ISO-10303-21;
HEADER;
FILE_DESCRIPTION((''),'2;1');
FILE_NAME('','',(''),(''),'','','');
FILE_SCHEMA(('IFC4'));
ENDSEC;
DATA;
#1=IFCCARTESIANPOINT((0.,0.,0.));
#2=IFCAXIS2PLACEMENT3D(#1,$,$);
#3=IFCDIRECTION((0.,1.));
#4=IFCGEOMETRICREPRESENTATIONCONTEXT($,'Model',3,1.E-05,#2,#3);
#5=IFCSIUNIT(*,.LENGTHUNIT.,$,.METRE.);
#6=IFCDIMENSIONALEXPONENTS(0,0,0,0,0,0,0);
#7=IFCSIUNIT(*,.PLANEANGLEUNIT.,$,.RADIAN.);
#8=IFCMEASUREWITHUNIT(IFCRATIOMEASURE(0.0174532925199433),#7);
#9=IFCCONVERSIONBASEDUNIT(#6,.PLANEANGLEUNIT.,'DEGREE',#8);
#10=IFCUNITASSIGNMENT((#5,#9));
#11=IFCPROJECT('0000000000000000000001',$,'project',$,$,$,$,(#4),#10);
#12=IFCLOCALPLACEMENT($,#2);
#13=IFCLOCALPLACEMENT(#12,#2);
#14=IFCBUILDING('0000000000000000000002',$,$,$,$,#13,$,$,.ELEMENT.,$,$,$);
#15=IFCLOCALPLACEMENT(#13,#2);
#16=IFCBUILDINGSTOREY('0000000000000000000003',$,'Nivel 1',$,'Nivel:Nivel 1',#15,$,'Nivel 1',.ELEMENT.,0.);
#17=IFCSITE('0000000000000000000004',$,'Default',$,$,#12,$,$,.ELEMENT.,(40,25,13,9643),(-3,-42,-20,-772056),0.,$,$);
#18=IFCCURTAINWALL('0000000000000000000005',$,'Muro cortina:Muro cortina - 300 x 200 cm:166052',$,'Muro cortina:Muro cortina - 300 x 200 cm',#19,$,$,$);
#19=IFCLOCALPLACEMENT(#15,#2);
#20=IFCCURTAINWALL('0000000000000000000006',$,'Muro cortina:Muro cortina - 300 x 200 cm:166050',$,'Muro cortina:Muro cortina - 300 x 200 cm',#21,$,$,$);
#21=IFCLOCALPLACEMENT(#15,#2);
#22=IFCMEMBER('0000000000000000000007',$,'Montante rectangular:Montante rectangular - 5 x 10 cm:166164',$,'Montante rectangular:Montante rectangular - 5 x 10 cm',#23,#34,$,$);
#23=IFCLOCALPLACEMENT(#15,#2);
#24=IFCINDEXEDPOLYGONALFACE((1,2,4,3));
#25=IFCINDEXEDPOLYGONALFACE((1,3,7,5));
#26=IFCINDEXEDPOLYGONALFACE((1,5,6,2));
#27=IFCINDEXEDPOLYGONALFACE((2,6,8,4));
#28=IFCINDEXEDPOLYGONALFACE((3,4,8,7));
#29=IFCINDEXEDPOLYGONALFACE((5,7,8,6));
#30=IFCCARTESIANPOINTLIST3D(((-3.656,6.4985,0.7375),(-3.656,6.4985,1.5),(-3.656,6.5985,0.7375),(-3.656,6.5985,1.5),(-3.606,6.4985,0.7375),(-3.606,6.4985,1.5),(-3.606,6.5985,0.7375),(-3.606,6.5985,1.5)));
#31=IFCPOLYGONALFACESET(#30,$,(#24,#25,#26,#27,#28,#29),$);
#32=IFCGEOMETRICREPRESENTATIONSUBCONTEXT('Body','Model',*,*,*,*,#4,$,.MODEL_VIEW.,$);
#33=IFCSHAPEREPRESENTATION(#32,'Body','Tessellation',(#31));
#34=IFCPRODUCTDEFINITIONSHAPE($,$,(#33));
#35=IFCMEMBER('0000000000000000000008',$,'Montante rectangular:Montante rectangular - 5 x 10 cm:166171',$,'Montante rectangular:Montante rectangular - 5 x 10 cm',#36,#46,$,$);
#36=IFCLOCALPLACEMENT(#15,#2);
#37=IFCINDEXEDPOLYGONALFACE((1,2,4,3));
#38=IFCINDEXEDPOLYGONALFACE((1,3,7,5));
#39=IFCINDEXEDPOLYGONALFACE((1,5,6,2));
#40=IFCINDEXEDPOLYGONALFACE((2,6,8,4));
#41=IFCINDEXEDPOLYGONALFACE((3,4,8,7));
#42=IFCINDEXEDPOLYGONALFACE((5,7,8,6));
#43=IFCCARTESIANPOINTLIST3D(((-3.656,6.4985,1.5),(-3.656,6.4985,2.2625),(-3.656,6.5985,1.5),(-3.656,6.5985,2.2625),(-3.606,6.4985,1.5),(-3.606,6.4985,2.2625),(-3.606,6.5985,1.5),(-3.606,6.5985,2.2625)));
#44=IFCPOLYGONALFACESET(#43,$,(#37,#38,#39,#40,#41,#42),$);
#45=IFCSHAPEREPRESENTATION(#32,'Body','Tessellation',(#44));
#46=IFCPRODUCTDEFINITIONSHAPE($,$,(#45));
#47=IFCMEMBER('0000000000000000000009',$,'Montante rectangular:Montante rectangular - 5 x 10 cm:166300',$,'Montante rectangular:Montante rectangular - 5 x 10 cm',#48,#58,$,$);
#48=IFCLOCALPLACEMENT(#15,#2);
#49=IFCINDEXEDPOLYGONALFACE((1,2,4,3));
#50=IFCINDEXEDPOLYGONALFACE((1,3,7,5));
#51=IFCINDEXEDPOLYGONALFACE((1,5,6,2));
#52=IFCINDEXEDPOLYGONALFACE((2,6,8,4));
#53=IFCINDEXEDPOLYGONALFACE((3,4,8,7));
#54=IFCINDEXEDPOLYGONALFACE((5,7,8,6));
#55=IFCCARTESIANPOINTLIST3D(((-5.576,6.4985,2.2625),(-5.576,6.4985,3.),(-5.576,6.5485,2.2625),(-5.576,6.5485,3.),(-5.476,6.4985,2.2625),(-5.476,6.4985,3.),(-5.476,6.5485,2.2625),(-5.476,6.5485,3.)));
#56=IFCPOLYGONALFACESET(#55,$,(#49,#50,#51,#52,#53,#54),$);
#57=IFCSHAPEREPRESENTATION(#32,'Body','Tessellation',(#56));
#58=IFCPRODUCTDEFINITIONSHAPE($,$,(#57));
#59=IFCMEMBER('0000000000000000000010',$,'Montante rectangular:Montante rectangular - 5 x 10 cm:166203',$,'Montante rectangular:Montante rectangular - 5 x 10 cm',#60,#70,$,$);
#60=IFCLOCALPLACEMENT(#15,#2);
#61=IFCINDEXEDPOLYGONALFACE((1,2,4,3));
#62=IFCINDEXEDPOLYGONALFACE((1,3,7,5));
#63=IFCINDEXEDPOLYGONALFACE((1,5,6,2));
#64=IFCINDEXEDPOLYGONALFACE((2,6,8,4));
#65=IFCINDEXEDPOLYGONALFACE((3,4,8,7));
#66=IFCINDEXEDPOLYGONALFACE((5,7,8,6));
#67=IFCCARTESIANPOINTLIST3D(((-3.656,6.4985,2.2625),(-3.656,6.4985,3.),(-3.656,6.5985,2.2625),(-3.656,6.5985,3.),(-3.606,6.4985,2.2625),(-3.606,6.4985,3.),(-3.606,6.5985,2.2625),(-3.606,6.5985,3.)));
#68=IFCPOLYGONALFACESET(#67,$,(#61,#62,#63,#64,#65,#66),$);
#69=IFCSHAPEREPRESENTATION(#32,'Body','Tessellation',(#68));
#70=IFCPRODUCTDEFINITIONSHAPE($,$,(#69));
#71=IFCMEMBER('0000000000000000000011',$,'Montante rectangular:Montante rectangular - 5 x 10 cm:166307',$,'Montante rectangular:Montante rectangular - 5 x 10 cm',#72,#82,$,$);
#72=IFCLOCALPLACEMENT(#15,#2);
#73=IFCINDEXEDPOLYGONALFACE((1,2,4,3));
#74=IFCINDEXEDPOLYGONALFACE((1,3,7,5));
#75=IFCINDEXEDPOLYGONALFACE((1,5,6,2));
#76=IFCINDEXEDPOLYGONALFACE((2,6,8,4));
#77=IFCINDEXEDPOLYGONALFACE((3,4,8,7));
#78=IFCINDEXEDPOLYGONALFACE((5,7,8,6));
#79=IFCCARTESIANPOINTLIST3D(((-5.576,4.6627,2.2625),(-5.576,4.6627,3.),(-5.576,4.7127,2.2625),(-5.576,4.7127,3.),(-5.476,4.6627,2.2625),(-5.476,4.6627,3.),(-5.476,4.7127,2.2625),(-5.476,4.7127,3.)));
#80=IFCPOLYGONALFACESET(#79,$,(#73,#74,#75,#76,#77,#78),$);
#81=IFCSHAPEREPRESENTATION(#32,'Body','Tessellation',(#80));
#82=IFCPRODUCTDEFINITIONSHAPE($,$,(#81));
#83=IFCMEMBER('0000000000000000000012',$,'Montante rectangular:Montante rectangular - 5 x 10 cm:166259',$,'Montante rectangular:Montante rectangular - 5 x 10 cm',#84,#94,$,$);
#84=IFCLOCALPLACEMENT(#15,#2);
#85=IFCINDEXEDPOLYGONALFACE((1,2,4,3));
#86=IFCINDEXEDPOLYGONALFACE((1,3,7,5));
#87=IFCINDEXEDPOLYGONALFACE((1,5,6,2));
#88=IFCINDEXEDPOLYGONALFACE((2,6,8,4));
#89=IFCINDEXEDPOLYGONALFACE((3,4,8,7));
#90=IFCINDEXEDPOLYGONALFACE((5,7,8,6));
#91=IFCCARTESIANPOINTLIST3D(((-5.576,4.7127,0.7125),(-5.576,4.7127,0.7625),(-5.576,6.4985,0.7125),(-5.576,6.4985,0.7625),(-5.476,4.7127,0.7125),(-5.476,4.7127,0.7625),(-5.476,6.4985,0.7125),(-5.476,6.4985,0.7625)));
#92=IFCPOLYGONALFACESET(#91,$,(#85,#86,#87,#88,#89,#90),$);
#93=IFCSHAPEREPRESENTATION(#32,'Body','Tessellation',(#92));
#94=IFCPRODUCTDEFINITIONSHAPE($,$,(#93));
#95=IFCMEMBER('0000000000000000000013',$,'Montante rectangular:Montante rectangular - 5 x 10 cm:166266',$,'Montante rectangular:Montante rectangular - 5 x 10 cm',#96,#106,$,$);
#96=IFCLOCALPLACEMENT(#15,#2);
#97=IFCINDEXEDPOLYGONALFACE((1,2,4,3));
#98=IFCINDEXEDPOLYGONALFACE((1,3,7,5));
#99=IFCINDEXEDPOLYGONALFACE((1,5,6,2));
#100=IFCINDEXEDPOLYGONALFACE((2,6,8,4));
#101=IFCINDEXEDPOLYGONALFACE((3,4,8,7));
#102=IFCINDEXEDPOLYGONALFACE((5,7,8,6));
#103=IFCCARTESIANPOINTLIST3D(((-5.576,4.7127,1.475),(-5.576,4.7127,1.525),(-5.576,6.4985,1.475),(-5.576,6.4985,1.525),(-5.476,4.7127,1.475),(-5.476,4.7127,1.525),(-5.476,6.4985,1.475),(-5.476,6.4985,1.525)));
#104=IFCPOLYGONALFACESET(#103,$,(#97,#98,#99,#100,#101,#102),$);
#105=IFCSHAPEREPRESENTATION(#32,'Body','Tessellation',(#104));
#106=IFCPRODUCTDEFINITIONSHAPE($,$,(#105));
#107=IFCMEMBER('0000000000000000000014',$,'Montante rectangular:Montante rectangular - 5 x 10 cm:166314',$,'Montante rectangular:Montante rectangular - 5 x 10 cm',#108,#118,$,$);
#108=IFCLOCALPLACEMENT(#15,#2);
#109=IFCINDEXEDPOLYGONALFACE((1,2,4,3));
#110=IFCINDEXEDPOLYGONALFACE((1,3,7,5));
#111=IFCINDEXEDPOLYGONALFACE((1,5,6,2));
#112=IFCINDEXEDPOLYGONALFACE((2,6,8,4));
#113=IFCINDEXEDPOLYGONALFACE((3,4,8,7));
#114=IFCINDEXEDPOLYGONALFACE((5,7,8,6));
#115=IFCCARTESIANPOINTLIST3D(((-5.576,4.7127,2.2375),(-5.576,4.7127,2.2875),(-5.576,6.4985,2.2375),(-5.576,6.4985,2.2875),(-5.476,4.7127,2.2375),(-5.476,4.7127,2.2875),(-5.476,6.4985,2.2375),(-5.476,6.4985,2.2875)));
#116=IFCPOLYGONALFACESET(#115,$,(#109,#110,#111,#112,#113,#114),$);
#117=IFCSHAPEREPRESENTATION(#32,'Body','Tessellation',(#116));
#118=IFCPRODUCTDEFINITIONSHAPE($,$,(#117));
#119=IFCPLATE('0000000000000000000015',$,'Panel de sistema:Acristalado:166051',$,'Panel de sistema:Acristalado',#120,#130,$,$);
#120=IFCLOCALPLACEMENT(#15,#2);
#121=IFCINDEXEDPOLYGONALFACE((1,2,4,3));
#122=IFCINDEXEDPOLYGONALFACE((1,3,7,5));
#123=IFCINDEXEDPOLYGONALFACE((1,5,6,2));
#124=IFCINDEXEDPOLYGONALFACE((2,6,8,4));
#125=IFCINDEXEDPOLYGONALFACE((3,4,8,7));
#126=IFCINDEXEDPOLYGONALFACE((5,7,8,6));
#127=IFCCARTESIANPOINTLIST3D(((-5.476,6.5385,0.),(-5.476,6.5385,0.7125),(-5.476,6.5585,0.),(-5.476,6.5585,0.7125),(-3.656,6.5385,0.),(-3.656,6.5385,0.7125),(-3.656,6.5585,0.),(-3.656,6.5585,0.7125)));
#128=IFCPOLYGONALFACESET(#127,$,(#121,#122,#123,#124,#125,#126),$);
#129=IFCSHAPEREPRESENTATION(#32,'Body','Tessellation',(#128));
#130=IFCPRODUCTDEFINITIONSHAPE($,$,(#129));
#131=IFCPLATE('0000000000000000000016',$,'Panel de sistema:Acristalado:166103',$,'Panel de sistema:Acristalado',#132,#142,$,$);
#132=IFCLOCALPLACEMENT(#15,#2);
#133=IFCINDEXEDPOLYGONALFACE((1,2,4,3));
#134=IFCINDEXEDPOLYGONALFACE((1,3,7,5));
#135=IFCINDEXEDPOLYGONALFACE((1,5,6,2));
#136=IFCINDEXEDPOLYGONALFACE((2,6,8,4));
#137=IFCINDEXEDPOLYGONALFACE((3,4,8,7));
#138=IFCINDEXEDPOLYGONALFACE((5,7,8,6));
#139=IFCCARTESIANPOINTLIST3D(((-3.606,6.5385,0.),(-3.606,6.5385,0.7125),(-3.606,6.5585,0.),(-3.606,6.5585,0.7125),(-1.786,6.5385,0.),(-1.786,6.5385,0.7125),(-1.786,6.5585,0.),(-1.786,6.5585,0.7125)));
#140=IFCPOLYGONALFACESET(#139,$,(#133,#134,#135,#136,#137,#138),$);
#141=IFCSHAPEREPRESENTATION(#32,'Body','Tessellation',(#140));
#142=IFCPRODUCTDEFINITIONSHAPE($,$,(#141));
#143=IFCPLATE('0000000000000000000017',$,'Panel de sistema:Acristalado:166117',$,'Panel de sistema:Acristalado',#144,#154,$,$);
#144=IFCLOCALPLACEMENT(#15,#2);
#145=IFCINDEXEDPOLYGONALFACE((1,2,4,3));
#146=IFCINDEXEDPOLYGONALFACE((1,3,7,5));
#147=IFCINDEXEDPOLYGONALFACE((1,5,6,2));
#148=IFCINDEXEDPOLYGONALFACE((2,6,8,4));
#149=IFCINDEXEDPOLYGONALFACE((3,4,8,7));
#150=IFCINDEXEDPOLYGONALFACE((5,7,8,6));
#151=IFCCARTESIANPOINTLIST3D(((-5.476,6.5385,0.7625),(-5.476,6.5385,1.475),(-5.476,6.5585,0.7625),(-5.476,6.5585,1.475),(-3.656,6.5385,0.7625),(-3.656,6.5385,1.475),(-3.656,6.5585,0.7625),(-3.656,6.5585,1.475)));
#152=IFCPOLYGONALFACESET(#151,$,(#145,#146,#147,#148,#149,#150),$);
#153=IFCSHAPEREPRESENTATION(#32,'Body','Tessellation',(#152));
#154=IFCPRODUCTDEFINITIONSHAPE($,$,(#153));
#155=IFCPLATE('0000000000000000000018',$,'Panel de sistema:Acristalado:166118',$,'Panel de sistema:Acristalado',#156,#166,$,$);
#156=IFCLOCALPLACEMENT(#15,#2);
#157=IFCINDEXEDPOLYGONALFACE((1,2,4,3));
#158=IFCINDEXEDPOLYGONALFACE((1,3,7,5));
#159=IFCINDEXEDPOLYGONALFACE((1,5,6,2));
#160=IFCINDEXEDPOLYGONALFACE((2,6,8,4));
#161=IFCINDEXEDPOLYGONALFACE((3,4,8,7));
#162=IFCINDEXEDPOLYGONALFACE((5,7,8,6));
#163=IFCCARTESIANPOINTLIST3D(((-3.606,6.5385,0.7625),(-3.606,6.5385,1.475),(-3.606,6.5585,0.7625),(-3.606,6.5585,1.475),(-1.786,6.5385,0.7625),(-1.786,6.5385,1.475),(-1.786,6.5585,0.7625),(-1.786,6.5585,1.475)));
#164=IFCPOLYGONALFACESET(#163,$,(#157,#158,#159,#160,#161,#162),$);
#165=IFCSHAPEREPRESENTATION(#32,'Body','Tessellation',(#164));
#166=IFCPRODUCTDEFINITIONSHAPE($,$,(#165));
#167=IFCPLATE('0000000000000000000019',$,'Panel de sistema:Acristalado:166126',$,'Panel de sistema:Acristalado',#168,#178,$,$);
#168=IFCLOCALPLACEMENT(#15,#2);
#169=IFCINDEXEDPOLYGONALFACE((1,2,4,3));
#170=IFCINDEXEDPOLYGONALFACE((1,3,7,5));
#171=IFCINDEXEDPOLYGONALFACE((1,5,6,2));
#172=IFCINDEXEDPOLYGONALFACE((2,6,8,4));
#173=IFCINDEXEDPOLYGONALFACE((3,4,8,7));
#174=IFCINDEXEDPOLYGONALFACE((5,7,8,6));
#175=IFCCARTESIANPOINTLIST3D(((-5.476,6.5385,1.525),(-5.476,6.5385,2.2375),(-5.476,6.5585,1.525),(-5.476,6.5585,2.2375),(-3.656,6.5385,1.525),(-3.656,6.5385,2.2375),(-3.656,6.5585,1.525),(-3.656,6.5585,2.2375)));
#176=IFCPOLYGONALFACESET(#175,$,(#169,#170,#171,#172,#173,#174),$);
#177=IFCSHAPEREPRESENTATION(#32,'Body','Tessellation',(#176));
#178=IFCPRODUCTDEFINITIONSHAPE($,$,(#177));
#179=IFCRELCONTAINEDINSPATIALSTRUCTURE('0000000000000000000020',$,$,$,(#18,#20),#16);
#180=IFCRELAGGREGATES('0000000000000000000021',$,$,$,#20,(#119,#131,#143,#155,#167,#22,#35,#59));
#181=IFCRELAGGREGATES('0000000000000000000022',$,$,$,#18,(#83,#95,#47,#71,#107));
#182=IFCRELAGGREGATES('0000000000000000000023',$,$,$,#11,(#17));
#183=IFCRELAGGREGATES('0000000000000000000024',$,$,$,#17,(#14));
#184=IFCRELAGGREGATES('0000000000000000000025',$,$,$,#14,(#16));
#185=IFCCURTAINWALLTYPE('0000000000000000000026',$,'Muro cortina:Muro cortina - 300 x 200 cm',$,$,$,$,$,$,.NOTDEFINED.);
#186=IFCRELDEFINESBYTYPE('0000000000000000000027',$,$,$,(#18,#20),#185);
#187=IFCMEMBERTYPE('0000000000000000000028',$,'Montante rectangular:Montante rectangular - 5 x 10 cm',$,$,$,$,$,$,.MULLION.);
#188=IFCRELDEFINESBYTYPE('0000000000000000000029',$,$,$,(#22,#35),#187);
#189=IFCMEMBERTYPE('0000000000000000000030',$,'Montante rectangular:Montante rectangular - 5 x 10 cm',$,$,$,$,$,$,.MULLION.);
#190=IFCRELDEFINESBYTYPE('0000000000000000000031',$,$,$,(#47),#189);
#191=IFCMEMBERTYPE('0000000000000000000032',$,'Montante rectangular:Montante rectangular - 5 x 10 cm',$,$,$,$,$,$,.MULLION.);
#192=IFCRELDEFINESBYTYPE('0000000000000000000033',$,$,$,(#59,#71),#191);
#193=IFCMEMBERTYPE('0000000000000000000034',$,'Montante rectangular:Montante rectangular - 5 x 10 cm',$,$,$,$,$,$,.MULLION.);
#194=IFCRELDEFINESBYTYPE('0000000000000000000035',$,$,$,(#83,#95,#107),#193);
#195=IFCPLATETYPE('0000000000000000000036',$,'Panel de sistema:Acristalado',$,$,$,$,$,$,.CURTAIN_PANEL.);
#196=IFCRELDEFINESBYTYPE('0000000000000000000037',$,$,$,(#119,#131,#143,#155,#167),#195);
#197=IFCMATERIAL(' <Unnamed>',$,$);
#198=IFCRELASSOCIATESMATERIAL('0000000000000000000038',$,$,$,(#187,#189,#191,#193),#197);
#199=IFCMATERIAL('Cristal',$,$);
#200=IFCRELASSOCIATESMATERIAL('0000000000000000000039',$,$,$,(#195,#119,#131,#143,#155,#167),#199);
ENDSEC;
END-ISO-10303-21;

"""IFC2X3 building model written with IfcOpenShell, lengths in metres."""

from ifc_helpers import new_model, entity, si_unit, converted_unit, direction, frame, origin, origin_2d_with_axis, place, context, subcontext, project, spatial, rectangle, extrude, source, transform, mapped, material, type_object, type_shapes, element, aggregate, save


model = new_model("IFC2X3")

# Units and contexts
model_context = context("Model", 3, precision=1e-05, world=origin(), true_north=direction((0.0, 1.0)))
body_context = subcontext(model_context, "Body", "Model", "MODEL_VIEW")
ifc_project = project(units=[si_unit("LENGTHUNIT", "METRE"), converted_unit("PLANEANGLEUNIT", "DEGREE", entity("IfcRatioMeasure", 0.0174532925199433), si_unit("PLANEANGLEUNIT", "RADIAN"), dimensions=[0, 0, 0, 0, 0, 0, 0])], contexts=[model_context])

# Site, building, storey
site_placement = place(None, origin())
site = spatial("IfcSite", under=ifc_project, at=site_placement, Name="Default", CompositionType="ELEMENT", RefLatitude=(40, 25, 13, 9643), RefLongitude=(-3, -42, -20, -772056), RefElevation=0.0)
building_placement = place(site_placement, origin())
building = spatial("IfcBuilding", under=site, at=building_placement, CompositionType="ELEMENT")
storey_placement = place(building_placement, origin())
storey = spatial("IfcBuildingStorey", under=building, at=storey_placement, Name="Nivel 1", ObjectType="Nivel:Nivel 1", LongName="Nivel 1", CompositionType="ELEMENT", Elevation=0.0)

# Curtain walls, members
curtain_wall_type = type_object("IfcCurtainWallType", Name="Muro cortina:Muro cortina - 300 x 200 cm", PredefinedType="NOTDEFINED")
curtain_wall_1_placement = place(storey_placement, origin())
curtain_wall_1 = element("IfcCurtainWall", 1, at=curtain_wall_1_placement, inside=storey, type_object=curtain_wall_type, Name="Muro cortina:Muro cortina - 300 x 200 cm:166052", ObjectType="Muro cortina:Muro cortina - 300 x 200 cm")
ifc_material_1 = material(Name=" <Unnamed>")
curtain_wall_2_placement = place(storey_placement, origin())
curtain_wall_2 = element("IfcCurtainWall", 2, at=curtain_wall_2_placement, inside=storey, type_object=curtain_wall_type, Name="Muro cortina:Muro cortina - 300 x 200 cm:166050", ObjectType="Muro cortina:Muro cortina - 300 x 200 cm")
member_type_1 = type_object("IfcMemberType", Name="Montante rectangular:Montante rectangular - 5 x 10 cm", PredefinedType="MULLION", material=ifc_material_1)
shared_shape_1 = source(origin(), body_context, "Body", "SweptSolid", [
    extrude(rectangle(XDim=0.1, YDim=0.05, at=origin_2d_with_axis()), frame((0.0, 0.0, -0.7625), z_axis=(0.0, 0.0, 1.0), x_axis=(0.0, -1.0, 0.0)), (0.0, 0.0, 1.0), 0.7625),
])
type_shapes(member_type_1, [shared_shape_1])
member_1_placement = place(storey_placement, frame((-3.631, 6.5485, 0.7375), z_axis=(0.0, 0.0, -1.0), x_axis=(1.0, 0.0, 0.0)))
member_1 = element("IfcMember", 3, at=member_1_placement, type_object=member_type_1, Name="Montante rectangular:Montante rectangular - 5 x 10 cm:166164", ObjectType="Montante rectangular:Montante rectangular - 5 x 10 cm", context=body_context, shape_type="MappedRepresentation", body=[
    mapped(shared_shape_1, transform((0.0, 0.0, 0.0), scale=1.0)),
])
member_2_placement = place(storey_placement, frame((-3.631, 6.5485, 1.5), z_axis=(0.0, 0.0, -1.0), x_axis=(1.0, 0.0, 0.0)))
member_2 = element("IfcMember", 4, at=member_2_placement, type_object=member_type_1, Name="Montante rectangular:Montante rectangular - 5 x 10 cm:166171", ObjectType="Montante rectangular:Montante rectangular - 5 x 10 cm", context=body_context, shape_type="MappedRepresentation", body=[
    mapped(shared_shape_1, transform((0.0, 0.0, 0.0), scale=1.0)),
])

# Members
member_type_2 = type_object("IfcMemberType", Name="Montante rectangular:Montante rectangular - 5 x 10 cm", PredefinedType="MULLION", material=ifc_material_1)
shared_shape_2 = source(origin(), body_context, "Body", "SweptSolid", [
    extrude(rectangle(XDim=0.1, YDim=0.05, at=origin_2d_with_axis()), frame((-0.025, 0.0, -0.7375), z_axis=(0.0, 0.0, 1.0), x_axis=(0.0, -1.0, 0.0)), (0.0, 0.0, 1.0), 0.7375),
])
type_shapes(member_type_2, [shared_shape_2])
member_3_placement = place(storey_placement, frame((-5.526, 6.5485, 2.2625), z_axis=(0.0, 0.0, -1.0), x_axis=(0.0, 1.0, 0.0)))
member_3 = element("IfcMember", 5, at=member_3_placement, type_object=member_type_2, Name="Montante rectangular:Montante rectangular - 5 x 10 cm:166300", ObjectType="Montante rectangular:Montante rectangular - 5 x 10 cm", context=body_context, shape_type="MappedRepresentation", body=[
    mapped(shared_shape_2, transform((0.0, 0.0, 0.0), scale=1.0)),
])
member_type_3 = type_object("IfcMemberType", Name="Montante rectangular:Montante rectangular - 5 x 10 cm", PredefinedType="MULLION", material=ifc_material_1)
shared_shape_3 = source(origin(), body_context, "Body", "SweptSolid", [
    extrude(rectangle(XDim=0.1, YDim=0.05, at=origin_2d_with_axis()), frame((0.0, 0.0, -0.7375), z_axis=(0.0, 0.0, 1.0), x_axis=(0.0, -1.0, 0.0)), (0.0, 0.0, 1.0), 0.7375),
])
type_shapes(member_type_3, [shared_shape_3])
member_4_placement = place(storey_placement, frame((-3.631, 6.5485, 2.2625), z_axis=(0.0, 0.0, -1.0), x_axis=(1.0, 0.0, 0.0)))
member_4 = element("IfcMember", 6, at=member_4_placement, type_object=member_type_3, Name="Montante rectangular:Montante rectangular - 5 x 10 cm:166203", ObjectType="Montante rectangular:Montante rectangular - 5 x 10 cm", context=body_context, shape_type="MappedRepresentation", body=[
    mapped(shared_shape_3, transform((0.0, 0.0, 0.0), scale=1.0)),
])
member_5_placement = place(storey_placement, frame((-5.526, 4.6877, 2.2625), z_axis=(0.0, 0.0, -1.0), x_axis=(0.0, 1.0, 0.0)))
member_5 = element("IfcMember", 7, at=member_5_placement, type_object=member_type_3, Name="Montante rectangular:Montante rectangular - 5 x 10 cm:166307", ObjectType="Montante rectangular:Montante rectangular - 5 x 10 cm", context=body_context, shape_type="MappedRepresentation", body=[
    mapped(shared_shape_3, transform((0.0, 0.0, 0.0), scale=1.0)),
])
member_type_4 = type_object("IfcMemberType", Name="Montante rectangular:Montante rectangular - 5 x 10 cm", PredefinedType="MULLION", material=ifc_material_1)
shared_shape_4 = source(origin(), body_context, "Body", "SweptSolid", [
    extrude(rectangle(XDim=0.1, YDim=0.05, at=origin_2d_with_axis()), frame((0.0, 0.0, -1.7857), z_axis=(0.0, 0.0, 1.0), x_axis=(0.0, -1.0, 0.0)), (0.0, 0.0, 1.0), 1.7857),
])
type_shapes(member_type_4, [shared_shape_4])
member_6_placement = place(storey_placement, frame((-5.526, 6.4985, 0.7375), z_axis=(0.0, 1.0, 0.0), x_axis=(0.0, 0.0, 1.0)))
member_6 = element("IfcMember", 8, at=member_6_placement, type_object=member_type_4, Name="Montante rectangular:Montante rectangular - 5 x 10 cm:166259", ObjectType="Montante rectangular:Montante rectangular - 5 x 10 cm", context=body_context, shape_type="MappedRepresentation", body=[
    mapped(shared_shape_4, transform((0.0, 0.0, 0.0), scale=1.0)),
])
member_7_placement = place(storey_placement, frame((-5.526, 6.4985, 1.5), z_axis=(0.0, 1.0, 0.0), x_axis=(0.0, 0.0, 1.0)))
member_7 = element("IfcMember", 9, at=member_7_placement, type_object=member_type_4, Name="Montante rectangular:Montante rectangular - 5 x 10 cm:166266", ObjectType="Montante rectangular:Montante rectangular - 5 x 10 cm", context=body_context, shape_type="MappedRepresentation", body=[
    mapped(shared_shape_4, transform((0.0, 0.0, 0.0), scale=1.0)),
])
member_8_placement = place(storey_placement, frame((-5.526, 6.4985, 2.2625), z_axis=(0.0, 1.0, 0.0), x_axis=(0.0, 0.0, 1.0)))
member_8 = element("IfcMember", 10, at=member_8_placement, type_object=member_type_4, Name="Montante rectangular:Montante rectangular - 5 x 10 cm:166314", ObjectType="Montante rectangular:Montante rectangular - 5 x 10 cm", context=body_context, shape_type="MappedRepresentation", body=[
    mapped(shared_shape_4, transform((0.0, 0.0, 0.0), scale=1.0)),
])

# Plates
ifc_material_2 = material(Name="Cristal")
plate_type_1 = type_object("IfcPlateType", Name="Panel de sistema:Acristalado", PredefinedType="CURTAIN_PANEL", material=ifc_material_2)
shared_shape_5 = source(origin(), body_context, "Body", "SweptSolid", [
    extrude(rectangle(XDim=0.02, YDim=1.82, at=origin_2d_with_axis()), frame((0.0, 0.0, 0.0), z_axis=(0.0, 0.0, 1.0), x_axis=(0.0, 1.0, 0.0)), (0.0, 0.0, 1.0), 0.7125),
])
type_shapes(plate_type_1, [shared_shape_5])
plate_1_placement = place(curtain_wall_2_placement, frame((-4.566, 6.5485, 0.0)))
plate_1 = element("IfcPlate", 11, at=plate_1_placement, type_object=plate_type_1, material=ifc_material_2, Name="Panel de sistema:Acristalado:166051", ObjectType="Panel de sistema:Acristalado", context=body_context, shape_type="MappedRepresentation", body=[
    mapped(shared_shape_5, transform((0.0, 0.0, 0.0), scale=1.0)),
])
plate_2_placement = place(curtain_wall_2_placement, frame((-2.696, 6.5485, 0.0)))
plate_2 = element("IfcPlate", 12, at=plate_2_placement, type_object=plate_type_1, material=ifc_material_2, Name="Panel de sistema:Acristalado:166103", ObjectType="Panel de sistema:Acristalado", context=body_context, shape_type="MappedRepresentation", body=[
    mapped(shared_shape_5, transform((0.0, 0.0, 0.0), scale=1.0)),
])
plate_3_placement = place(curtain_wall_2_placement, frame((-4.566, 6.5485, 0.7625)))
plate_3 = element("IfcPlate", 13, at=plate_3_placement, type_object=plate_type_1, material=ifc_material_2, Name="Panel de sistema:Acristalado:166117", ObjectType="Panel de sistema:Acristalado", context=body_context, shape_type="MappedRepresentation", body=[
    mapped(shared_shape_5, transform((0.0, 0.0, 0.0), scale=1.0)),
])
plate_4_placement = place(curtain_wall_2_placement, frame((-2.696, 6.5485, 0.7625)))
plate_4 = element("IfcPlate", 14, at=plate_4_placement, type_object=plate_type_1, material=ifc_material_2, Name="Panel de sistema:Acristalado:166118", ObjectType="Panel de sistema:Acristalado", context=body_context, shape_type="MappedRepresentation", body=[
    mapped(shared_shape_5, transform((0.0, 0.0, 0.0), scale=1.0)),
])
plate_5_placement = place(curtain_wall_2_placement, frame((-4.566, 6.5485, 1.525)))
plate_5 = element("IfcPlate", 15, at=plate_5_placement, type_object=plate_type_1, material=ifc_material_2, Name="Panel de sistema:Acristalado:166126", ObjectType="Panel de sistema:Acristalado", context=body_context, shape_type="MappedRepresentation", body=[
    mapped(shared_shape_5, transform((0.0, 0.0, 0.0), scale=1.0)),
])
aggregate(curtain_wall_2, [plate_1, plate_2, plate_3, plate_4, plate_5, member_1, member_2, member_4])
aggregate(curtain_wall_1, [member_6, member_7, member_3, member_5, member_8])

save(model, "model.ifc")
